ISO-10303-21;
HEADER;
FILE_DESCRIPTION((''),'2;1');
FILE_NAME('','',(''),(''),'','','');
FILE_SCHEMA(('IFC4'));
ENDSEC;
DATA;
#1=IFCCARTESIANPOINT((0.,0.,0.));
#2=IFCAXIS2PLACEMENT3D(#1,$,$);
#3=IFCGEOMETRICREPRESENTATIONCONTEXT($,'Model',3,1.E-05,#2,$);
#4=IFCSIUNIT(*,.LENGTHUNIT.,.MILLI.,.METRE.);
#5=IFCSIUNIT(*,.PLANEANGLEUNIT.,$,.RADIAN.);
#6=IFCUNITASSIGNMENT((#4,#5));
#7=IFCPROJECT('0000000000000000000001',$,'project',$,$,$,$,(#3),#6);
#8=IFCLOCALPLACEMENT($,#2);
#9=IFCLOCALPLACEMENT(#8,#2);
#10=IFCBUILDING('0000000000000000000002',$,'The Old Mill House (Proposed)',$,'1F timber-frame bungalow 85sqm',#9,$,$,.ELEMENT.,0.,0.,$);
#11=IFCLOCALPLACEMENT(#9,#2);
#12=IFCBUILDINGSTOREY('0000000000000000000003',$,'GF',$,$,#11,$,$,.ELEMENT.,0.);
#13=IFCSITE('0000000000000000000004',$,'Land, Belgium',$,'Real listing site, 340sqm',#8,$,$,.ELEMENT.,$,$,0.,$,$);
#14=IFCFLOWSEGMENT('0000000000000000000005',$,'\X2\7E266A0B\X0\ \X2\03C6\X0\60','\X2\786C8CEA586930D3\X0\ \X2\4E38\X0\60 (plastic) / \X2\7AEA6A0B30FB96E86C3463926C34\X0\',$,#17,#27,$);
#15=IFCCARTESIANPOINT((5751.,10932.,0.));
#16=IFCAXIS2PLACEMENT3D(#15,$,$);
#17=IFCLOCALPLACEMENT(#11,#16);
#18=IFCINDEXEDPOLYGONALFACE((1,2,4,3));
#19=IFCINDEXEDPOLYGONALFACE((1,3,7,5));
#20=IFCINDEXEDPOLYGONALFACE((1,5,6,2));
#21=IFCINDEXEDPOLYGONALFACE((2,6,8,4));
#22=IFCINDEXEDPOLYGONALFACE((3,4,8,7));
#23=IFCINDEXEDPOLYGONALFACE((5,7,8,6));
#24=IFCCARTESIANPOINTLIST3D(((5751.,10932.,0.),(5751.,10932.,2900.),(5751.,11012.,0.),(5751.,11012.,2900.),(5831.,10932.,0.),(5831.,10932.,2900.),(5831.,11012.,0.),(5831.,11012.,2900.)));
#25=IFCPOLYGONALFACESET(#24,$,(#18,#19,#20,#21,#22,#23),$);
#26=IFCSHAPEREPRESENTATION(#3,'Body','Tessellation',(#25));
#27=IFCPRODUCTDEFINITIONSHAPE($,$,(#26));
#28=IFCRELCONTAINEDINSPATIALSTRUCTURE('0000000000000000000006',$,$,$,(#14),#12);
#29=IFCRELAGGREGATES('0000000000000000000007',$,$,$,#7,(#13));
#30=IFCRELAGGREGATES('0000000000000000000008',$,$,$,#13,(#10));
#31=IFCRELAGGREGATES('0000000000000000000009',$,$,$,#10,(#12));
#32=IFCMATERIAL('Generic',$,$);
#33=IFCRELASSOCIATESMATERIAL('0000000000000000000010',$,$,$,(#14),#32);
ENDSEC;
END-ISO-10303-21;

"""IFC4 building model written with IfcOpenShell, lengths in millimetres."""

from ifc_helpers import new_model, si_unit, frame, frame_2d, origin, place, context, project, spatial, rectangle, extrude, material, element, save


model = new_model("IFC4")

# Units and contexts
model_context = context("Model", 3, precision=1e-05, world=origin())
ifc_project = project(units=[si_unit("LENGTHUNIT", "METRE", prefix="MILLI"), si_unit("PLANEANGLEUNIT", "RADIAN")], contexts=[model_context])

# Site, building, storey
site_placement = place(None, origin())
site = spatial("IfcSite", under=ifc_project, at=site_placement, Name="Land, Belgium", ObjectType="Real listing site, 340sqm", CompositionType="ELEMENT", RefElevation=0.0)
building_placement = place(site_placement, origin())
building = spatial("IfcBuilding", under=site, at=building_placement, Name="The Old Mill House (Proposed)", ObjectType="1F timber-frame bungalow 85sqm", CompositionType="ELEMENT", ElevationOfRefHeight=0.0, ElevationOfTerrain=0.0)
storey_placement = place(building_placement, origin())
storey = spatial("IfcBuildingStorey", under=building, at=storey_placement, Name="GF", CompositionType="ELEMENT", Elevation=0.0)

# Shared definitions
ifc_material_1 = material(Name="Generic")

# Flow segment
flow_segment_1_placement = place(storey_placement, frame((5751.0, 10932.0, 0.0)))
element("IfcFlowSegment", 1, at=flow_segment_1_placement, inside=storey, material=ifc_material_1, Name="縦樋 φ60", Description="硬質塩ビ 丸60 (plastic) / 竪樋・雨水排水", context=model_context, shape_type="SweptSolid", body=[
    extrude(rectangle(XDim=80.0, YDim=80.0, at=frame_2d((40.0, 40.0))), frame((5751.0, 10932.0, 0.0)), (0.0, 0.0, 1.0), 2900.0),
])

save(model, "model.ifc")
